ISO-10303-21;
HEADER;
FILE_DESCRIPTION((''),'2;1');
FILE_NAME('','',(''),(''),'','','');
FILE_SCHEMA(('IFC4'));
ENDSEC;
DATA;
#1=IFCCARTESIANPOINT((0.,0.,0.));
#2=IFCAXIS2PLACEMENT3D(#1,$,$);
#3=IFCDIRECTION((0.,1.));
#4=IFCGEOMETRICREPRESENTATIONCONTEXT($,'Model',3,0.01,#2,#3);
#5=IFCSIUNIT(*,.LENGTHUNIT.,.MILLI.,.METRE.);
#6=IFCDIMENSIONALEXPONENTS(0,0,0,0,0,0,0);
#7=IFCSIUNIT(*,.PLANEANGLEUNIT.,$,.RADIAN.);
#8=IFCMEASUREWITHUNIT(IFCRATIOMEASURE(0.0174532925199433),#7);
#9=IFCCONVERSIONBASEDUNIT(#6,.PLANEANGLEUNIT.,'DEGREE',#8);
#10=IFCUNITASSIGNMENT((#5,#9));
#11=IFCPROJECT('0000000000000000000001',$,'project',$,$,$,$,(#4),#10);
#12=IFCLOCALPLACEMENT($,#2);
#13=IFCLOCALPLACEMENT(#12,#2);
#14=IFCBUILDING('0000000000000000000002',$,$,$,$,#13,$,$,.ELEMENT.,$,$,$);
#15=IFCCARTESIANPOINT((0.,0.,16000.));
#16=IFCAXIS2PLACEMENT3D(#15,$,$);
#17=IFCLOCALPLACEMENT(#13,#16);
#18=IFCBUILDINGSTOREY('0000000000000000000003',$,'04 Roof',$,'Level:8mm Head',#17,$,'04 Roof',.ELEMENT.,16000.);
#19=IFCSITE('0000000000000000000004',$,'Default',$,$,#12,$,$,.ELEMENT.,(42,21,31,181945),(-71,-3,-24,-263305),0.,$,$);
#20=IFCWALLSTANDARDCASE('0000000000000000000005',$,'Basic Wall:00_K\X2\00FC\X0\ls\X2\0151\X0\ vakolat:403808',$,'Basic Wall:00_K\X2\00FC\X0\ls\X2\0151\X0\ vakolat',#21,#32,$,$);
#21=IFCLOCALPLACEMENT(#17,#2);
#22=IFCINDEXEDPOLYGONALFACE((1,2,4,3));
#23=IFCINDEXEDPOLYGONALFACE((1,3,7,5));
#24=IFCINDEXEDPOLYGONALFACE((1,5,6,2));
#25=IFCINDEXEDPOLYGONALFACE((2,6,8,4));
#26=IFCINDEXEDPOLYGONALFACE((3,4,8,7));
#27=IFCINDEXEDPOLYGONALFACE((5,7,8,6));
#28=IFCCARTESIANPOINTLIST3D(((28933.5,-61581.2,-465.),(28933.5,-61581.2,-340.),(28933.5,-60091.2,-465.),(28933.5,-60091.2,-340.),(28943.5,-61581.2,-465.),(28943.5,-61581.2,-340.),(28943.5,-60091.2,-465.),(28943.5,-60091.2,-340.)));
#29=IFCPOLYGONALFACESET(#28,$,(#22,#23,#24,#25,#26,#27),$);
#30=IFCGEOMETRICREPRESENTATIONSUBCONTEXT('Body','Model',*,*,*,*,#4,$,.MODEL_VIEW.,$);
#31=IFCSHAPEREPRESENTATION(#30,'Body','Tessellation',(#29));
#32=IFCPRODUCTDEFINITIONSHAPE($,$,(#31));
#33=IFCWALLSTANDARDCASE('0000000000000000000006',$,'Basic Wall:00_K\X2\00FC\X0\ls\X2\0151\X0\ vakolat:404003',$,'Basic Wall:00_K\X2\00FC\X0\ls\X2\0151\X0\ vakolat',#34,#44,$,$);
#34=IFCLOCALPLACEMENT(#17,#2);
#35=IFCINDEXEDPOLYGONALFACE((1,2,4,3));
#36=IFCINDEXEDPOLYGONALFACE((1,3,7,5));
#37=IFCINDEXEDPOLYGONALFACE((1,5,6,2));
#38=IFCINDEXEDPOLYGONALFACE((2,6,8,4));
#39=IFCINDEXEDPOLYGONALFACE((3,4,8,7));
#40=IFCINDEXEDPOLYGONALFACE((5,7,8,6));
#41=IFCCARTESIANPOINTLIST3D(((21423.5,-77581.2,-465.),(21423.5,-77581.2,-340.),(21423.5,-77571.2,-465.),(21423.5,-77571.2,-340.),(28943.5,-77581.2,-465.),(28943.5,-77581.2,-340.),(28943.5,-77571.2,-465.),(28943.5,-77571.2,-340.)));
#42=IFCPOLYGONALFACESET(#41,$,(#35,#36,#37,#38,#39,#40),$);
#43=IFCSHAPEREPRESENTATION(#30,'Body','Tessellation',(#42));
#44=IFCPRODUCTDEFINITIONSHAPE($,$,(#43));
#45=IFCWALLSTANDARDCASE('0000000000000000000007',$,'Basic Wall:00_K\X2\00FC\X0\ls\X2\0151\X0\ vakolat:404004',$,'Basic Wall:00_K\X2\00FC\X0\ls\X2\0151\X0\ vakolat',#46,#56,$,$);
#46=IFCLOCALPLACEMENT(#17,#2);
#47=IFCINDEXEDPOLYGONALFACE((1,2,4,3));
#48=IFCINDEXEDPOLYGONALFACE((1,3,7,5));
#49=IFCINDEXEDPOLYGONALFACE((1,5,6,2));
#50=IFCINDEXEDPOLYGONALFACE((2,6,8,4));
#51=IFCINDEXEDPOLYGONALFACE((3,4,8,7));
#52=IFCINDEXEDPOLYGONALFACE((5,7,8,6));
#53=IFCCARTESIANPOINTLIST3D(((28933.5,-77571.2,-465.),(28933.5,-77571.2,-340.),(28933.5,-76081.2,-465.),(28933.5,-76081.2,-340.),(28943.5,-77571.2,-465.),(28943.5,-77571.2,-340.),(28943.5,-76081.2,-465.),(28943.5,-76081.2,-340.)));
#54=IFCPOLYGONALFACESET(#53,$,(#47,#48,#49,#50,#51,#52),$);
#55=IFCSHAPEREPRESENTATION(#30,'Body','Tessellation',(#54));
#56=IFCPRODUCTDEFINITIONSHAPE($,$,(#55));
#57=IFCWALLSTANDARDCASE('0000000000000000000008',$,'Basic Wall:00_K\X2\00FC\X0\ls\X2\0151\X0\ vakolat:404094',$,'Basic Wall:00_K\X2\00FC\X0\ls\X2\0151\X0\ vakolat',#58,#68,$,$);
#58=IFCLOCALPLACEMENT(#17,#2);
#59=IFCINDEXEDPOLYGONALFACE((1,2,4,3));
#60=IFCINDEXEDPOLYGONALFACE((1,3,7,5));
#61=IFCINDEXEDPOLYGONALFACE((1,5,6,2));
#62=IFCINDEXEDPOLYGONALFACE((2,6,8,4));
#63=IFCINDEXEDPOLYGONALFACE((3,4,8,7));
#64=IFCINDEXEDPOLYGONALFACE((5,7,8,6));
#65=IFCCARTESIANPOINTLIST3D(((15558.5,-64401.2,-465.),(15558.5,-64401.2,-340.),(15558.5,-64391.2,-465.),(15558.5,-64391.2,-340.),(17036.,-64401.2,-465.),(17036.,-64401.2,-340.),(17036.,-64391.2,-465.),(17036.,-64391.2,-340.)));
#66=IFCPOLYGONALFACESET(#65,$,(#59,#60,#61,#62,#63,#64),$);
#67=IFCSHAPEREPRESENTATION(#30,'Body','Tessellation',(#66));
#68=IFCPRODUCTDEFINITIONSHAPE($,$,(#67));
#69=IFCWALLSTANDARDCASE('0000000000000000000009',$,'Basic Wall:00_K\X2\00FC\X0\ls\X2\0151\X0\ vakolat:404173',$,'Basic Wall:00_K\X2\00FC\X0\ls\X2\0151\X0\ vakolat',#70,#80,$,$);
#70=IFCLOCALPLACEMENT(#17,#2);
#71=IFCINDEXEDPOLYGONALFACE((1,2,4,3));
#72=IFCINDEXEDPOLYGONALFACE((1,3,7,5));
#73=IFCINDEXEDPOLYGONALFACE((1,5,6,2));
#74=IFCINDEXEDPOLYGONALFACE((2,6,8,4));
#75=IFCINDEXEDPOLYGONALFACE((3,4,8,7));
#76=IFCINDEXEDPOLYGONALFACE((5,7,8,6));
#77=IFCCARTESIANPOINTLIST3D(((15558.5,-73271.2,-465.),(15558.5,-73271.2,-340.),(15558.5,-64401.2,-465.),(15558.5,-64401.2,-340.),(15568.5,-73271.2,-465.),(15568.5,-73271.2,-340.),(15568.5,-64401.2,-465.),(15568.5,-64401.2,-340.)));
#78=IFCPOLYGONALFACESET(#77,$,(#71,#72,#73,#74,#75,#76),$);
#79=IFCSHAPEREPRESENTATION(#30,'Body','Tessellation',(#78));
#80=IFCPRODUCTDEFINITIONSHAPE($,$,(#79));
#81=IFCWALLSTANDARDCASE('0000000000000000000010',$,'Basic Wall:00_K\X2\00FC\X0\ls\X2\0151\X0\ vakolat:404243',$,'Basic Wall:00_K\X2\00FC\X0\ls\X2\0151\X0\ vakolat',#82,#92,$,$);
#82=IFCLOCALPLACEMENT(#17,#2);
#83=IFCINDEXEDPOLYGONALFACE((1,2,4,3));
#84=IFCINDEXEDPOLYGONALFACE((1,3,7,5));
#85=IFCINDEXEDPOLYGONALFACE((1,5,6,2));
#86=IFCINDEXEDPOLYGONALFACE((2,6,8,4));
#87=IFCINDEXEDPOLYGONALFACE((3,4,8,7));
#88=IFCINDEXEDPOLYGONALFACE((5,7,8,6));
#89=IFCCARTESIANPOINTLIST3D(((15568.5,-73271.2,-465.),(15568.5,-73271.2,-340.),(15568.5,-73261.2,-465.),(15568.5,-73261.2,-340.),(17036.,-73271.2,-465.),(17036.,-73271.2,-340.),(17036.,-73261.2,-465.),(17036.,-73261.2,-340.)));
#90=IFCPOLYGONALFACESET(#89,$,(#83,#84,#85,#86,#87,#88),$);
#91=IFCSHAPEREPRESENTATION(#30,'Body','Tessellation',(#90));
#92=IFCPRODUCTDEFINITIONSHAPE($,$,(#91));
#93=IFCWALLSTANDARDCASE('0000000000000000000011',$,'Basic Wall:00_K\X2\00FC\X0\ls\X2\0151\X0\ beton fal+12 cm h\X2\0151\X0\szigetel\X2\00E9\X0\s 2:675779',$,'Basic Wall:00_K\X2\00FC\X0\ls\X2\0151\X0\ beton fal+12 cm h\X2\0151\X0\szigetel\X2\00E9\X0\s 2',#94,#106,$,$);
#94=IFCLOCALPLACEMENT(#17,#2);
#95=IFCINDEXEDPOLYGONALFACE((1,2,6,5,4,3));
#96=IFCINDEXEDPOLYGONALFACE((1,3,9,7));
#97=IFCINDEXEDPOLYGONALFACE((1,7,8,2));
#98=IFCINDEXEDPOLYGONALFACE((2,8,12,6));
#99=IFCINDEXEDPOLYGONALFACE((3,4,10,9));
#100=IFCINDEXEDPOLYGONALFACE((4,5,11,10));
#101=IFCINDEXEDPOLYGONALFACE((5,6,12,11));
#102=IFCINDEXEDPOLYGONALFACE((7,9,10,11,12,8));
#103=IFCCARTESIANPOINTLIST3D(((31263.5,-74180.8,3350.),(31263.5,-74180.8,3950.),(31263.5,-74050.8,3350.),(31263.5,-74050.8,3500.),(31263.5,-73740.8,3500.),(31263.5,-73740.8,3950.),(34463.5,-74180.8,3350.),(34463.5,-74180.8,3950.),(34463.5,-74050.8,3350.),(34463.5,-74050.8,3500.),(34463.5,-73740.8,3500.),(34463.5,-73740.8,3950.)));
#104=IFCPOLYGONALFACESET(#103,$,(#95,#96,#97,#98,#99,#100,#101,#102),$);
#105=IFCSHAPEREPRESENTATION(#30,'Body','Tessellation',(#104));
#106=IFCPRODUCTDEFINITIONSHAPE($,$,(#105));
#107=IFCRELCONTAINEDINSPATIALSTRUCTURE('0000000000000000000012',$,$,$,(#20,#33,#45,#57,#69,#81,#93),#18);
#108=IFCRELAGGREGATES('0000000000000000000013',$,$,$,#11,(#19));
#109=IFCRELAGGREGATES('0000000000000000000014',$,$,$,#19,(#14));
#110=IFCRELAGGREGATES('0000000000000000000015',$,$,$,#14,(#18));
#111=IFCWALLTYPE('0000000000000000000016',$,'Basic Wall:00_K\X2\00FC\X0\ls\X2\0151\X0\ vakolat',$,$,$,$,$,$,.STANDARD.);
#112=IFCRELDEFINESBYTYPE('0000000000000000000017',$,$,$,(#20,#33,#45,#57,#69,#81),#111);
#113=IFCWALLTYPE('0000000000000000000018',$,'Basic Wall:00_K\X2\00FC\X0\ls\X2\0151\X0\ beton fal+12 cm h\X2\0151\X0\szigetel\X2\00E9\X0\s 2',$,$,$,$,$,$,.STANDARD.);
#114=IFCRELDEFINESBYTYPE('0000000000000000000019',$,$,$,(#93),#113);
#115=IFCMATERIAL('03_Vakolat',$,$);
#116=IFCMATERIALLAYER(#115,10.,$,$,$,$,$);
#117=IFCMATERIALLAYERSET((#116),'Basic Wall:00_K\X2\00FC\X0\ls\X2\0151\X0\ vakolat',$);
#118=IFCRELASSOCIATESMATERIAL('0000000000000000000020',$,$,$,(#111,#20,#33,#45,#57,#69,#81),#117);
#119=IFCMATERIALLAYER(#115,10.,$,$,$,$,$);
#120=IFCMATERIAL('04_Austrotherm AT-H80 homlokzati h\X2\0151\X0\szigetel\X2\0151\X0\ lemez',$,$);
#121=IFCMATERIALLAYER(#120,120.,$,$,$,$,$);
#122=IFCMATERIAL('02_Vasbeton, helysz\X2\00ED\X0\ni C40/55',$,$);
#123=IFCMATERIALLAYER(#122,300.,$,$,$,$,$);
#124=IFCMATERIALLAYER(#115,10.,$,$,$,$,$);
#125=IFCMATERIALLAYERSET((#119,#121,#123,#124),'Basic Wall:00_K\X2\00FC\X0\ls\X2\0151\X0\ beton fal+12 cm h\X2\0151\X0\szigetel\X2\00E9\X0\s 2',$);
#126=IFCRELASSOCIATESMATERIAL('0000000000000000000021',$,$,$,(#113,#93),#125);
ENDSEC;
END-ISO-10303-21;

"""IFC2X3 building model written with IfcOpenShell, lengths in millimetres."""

from ifc_helpers import new_model, entity, si_unit, converted_unit, direction, frame, frame_2d, origin, place, context, subcontext, project, spatial, polyline, rectangle, extrude, clip, bounded_halfspace, material, layer, layer_set, layer_usage, type_object, element, save


model = new_model("IFC2X3")

# Units and contexts
model_context = context("Model", 3, precision=0.01, world=origin(), true_north=direction((0.0, 1.0)))
body_context = subcontext(model_context, "Body", "Model", "MODEL_VIEW")
ifc_project = project(units=[si_unit("LENGTHUNIT", "METRE", prefix="MILLI"), converted_unit("PLANEANGLEUNIT", "DEGREE", entity("IfcRatioMeasure", 0.0174532925199433), si_unit("PLANEANGLEUNIT", "RADIAN"), dimensions=[0, 0, 0, 0, 0, 0, 0])], contexts=[model_context])

# Site, building, storey
site_placement = place(None, origin())
site = spatial("IfcSite", under=ifc_project, at=site_placement, Name="Default", CompositionType="ELEMENT", RefLatitude=(42, 21, 31, 181945), RefLongitude=(-71, -3, -24, -263305), RefElevation=0.0)
building_placement = place(site_placement, origin())
building = spatial("IfcBuilding", under=site, at=building_placement, CompositionType="ELEMENT")
storey_placement = place(building_placement, frame((0.0, 0.0, 16000.0)))
storey = spatial("IfcBuildingStorey", under=building, at=storey_placement, Name="04 Roof", ObjectType="Level:8mm Head", LongName="04 Roof", CompositionType="ELEMENT", Elevation=16000.0)

# Shared definitions
ifc_material_1 = material(Name="03_Vakolat")

# Walls
ifc_layer_1 = layer(ifc_material_1, 10.0)
ifc_layer_set_1 = layer_set([ifc_layer_1], Name="Basic Wall:00_Külső vakolat")
wall_type_1 = type_object("IfcWallType", Name="Basic Wall:00_Külső vakolat", PredefinedType="STANDARD", material=ifc_layer_set_1)
ifc_layer_usage_1 = layer_usage(ifc_layer_set_1, "AXIS2", "NEGATIVE", 5.0)
wall_1_placement = place(storey_placement, frame((28938.5, -61581.2, -465.0), z_axis=(0.0, 0.0, 1.0), x_axis=(0.0, 1.0, 0.0)))
element("IfcWallStandardCase", 1, at=wall_1_placement, inside=storey, type_object=wall_type_1, material=ifc_layer_usage_1, Name="Basic Wall:00_Külső vakolat:403808", ObjectType="Basic Wall:00_Külső vakolat", context=body_context, shape_type="SweptSolid", body=[
    extrude(rectangle(XDim=1490.0, YDim=10.0, at=frame_2d((745.0, 0.0), x_axis=(-1.0, 0.0))), origin(), (0.0, 0.0, 1.0), 125.0),
])
ifc_layer_usage_2 = layer_usage(ifc_layer_set_1, "AXIS2", "POSITIVE", -5.0)
wall_2_placement = place(storey_placement, frame((28943.5, -77576.2, -465.0), z_axis=(0.0, 0.0, 1.0), x_axis=(-1.0, 0.0, 0.0)))
element("IfcWallStandardCase", 2, at=wall_2_placement, inside=storey, type_object=wall_type_1, material=ifc_layer_usage_2, Name="Basic Wall:00_Külső vakolat:404003", ObjectType="Basic Wall:00_Külső vakolat", context=body_context, shape_type="SweptSolid", body=[
    extrude(rectangle(XDim=7520.0, YDim=10.0, at=frame_2d((3760.0, 0.0), x_axis=(-1.0, 0.0))), origin(), (0.0, 0.0, 1.0), 125.0),
])
ifc_layer_usage_3 = layer_usage(ifc_layer_set_1, "AXIS2", "POSITIVE", -5.0)
wall_3_placement = place(storey_placement, frame((28938.5, -76081.2, -465.0), z_axis=(0.0, 0.0, 1.0), x_axis=(0.0, -1.0, 0.0)))
element("IfcWallStandardCase", 3, at=wall_3_placement, inside=storey, type_object=wall_type_1, material=ifc_layer_usage_3, Name="Basic Wall:00_Külső vakolat:404004", ObjectType="Basic Wall:00_Külső vakolat", context=body_context, shape_type="SweptSolid", body=[
    extrude(rectangle(XDim=1490.0, YDim=10.0, at=frame_2d((745.0, 0.0), x_axis=(-1.0, 0.0))), origin(), (0.0, 0.0, 1.0), 125.0),
])
ifc_layer_usage_4 = layer_usage(ifc_layer_set_1, "AXIS2", "NEGATIVE", 5.0)
wall_4_placement = place(storey_placement, frame((17036.0, -64396.2, -465.0), z_axis=(0.0, 0.0, 1.0), x_axis=(-1.0, 0.0, 0.0)))
element("IfcWallStandardCase", 4, at=wall_4_placement, inside=storey, type_object=wall_type_1, material=ifc_layer_usage_4, Name="Basic Wall:00_Külső vakolat:404094", ObjectType="Basic Wall:00_Külső vakolat", context=body_context, shape_type="SweptSolid", body=[
    extrude(rectangle(XDim=1477.5, YDim=10.0, at=frame_2d((738.7, 0.0), x_axis=(-1.0, 0.0))), origin(), (0.0, 0.0, 1.0), 125.0),
])
ifc_layer_usage_5 = layer_usage(ifc_layer_set_1, "AXIS2", "NEGATIVE", 5.0)
wall_5_placement = place(storey_placement, frame((15563.5, -64401.2, -465.0), z_axis=(0.0, 0.0, 1.0), x_axis=(0.0, -1.0, 0.0)))
element("IfcWallStandardCase", 5, at=wall_5_placement, inside=storey, type_object=wall_type_1, material=ifc_layer_usage_5, Name="Basic Wall:00_Külső vakolat:404173", ObjectType="Basic Wall:00_Külső vakolat", context=body_context, shape_type="SweptSolid", body=[
    extrude(rectangle(XDim=8870.0, YDim=10.0, at=frame_2d((4435.0, 0.0), x_axis=(-1.0, 0.0))), origin(), (0.0, 0.0, 1.0), 125.0),
])
ifc_layer_usage_6 = layer_usage(ifc_layer_set_1, "AXIS2", "POSITIVE", -5.0)
wall_6_placement = place(storey_placement, frame((17036.0, -73266.2, -465.0), z_axis=(0.0, 0.0, 1.0), x_axis=(-1.0, 0.0, 0.0)))
element("IfcWallStandardCase", 6, at=wall_6_placement, inside=storey, type_object=wall_type_1, material=ifc_layer_usage_6, Name="Basic Wall:00_Külső vakolat:404243", ObjectType="Basic Wall:00_Külső vakolat", context=body_context, shape_type="SweptSolid", body=[
    extrude(rectangle(XDim=1467.5, YDim=10.0, at=frame_2d((733.7, 0.0), x_axis=(-1.0, 0.0))), origin(), (0.0, 0.0, 1.0), 125.0),
])
ifc_layer_2 = layer(ifc_material_1, 10.0)
ifc_material_2 = material(Name="04_Austrotherm AT-H80 homlokzati hőszigetelő lemez")
ifc_layer_3 = layer(ifc_material_2, 120.0)
ifc_material_3 = material(Name="02_Vasbeton, helyszíni C40/55")
ifc_layer_4 = layer(ifc_material_3, 300.0)
ifc_layer_5 = layer(ifc_material_1, 10.0)
ifc_layer_set_2 = layer_set([ifc_layer_2, ifc_layer_3, ifc_layer_4, ifc_layer_5], Name="Basic Wall:00_Külső beton fal+12 cm hőszigetelés 2")
ifc_layer_usage_7 = layer_usage(ifc_layer_set_2, "AXIS2", "POSITIVE", -220.0)
wall_type_2 = type_object("IfcWallType", Name="Basic Wall:00_Külső beton fal+12 cm hőszigetelés 2", PredefinedType="STANDARD", material=ifc_layer_set_2)
wall_7_placement = place(storey_placement, frame((31263.5, -73960.8, 3350.0)))
element("IfcWallStandardCase", 7, at=wall_7_placement, inside=storey, type_object=wall_type_2, material=ifc_layer_usage_7, Name="Basic Wall:00_Külső beton fal+12 cm hőszigetelés 2:675779", ObjectType="Basic Wall:00_Külső beton fal+12 cm hőszigetelés 2", context=body_context, shape_type="Clipping", body=[
    clip(clip(extrude(rectangle(XDim=3200.0, YDim=440.0, at=frame_2d((1600.0, 0.0), x_axis=(-1.0, 0.0))), origin(), (0.0, 0.0, 1.0), 600.0), bounded_halfspace(frame((3200.0, -90.0, 150.0), z_axis=(0.0, 0.0, 1.0), x_axis=(0.0, 1.0, 0.0)), True, frame((3200.0, -90.0, 150.0), z_axis=(0.0, 0.0, 1.0), x_axis=(0.0, 1.0, 0.0)), polyline([(0.0, 0.0), (310.0, 0.0), (310.0, 3200.0), (0.0, 3200.0), (0.0, 0.0)]))), bounded_halfspace(frame((0.0, -90.0, 150.0), z_axis=(0.0, -1.0, 0.0), x_axis=(0.0, 0.0, 1.0)), True, frame((0.0, -90.0, 150.0), z_axis=(0.0, -1.0, 0.0), x_axis=(0.0, 0.0, 1.0)), polyline([(0.0, 0.0), (-150.0, 0.0), (-150.0, -3200.0), (0.0, -3200.0), (0.0, 0.0)]))),
])

save(model, "model.ifc")
